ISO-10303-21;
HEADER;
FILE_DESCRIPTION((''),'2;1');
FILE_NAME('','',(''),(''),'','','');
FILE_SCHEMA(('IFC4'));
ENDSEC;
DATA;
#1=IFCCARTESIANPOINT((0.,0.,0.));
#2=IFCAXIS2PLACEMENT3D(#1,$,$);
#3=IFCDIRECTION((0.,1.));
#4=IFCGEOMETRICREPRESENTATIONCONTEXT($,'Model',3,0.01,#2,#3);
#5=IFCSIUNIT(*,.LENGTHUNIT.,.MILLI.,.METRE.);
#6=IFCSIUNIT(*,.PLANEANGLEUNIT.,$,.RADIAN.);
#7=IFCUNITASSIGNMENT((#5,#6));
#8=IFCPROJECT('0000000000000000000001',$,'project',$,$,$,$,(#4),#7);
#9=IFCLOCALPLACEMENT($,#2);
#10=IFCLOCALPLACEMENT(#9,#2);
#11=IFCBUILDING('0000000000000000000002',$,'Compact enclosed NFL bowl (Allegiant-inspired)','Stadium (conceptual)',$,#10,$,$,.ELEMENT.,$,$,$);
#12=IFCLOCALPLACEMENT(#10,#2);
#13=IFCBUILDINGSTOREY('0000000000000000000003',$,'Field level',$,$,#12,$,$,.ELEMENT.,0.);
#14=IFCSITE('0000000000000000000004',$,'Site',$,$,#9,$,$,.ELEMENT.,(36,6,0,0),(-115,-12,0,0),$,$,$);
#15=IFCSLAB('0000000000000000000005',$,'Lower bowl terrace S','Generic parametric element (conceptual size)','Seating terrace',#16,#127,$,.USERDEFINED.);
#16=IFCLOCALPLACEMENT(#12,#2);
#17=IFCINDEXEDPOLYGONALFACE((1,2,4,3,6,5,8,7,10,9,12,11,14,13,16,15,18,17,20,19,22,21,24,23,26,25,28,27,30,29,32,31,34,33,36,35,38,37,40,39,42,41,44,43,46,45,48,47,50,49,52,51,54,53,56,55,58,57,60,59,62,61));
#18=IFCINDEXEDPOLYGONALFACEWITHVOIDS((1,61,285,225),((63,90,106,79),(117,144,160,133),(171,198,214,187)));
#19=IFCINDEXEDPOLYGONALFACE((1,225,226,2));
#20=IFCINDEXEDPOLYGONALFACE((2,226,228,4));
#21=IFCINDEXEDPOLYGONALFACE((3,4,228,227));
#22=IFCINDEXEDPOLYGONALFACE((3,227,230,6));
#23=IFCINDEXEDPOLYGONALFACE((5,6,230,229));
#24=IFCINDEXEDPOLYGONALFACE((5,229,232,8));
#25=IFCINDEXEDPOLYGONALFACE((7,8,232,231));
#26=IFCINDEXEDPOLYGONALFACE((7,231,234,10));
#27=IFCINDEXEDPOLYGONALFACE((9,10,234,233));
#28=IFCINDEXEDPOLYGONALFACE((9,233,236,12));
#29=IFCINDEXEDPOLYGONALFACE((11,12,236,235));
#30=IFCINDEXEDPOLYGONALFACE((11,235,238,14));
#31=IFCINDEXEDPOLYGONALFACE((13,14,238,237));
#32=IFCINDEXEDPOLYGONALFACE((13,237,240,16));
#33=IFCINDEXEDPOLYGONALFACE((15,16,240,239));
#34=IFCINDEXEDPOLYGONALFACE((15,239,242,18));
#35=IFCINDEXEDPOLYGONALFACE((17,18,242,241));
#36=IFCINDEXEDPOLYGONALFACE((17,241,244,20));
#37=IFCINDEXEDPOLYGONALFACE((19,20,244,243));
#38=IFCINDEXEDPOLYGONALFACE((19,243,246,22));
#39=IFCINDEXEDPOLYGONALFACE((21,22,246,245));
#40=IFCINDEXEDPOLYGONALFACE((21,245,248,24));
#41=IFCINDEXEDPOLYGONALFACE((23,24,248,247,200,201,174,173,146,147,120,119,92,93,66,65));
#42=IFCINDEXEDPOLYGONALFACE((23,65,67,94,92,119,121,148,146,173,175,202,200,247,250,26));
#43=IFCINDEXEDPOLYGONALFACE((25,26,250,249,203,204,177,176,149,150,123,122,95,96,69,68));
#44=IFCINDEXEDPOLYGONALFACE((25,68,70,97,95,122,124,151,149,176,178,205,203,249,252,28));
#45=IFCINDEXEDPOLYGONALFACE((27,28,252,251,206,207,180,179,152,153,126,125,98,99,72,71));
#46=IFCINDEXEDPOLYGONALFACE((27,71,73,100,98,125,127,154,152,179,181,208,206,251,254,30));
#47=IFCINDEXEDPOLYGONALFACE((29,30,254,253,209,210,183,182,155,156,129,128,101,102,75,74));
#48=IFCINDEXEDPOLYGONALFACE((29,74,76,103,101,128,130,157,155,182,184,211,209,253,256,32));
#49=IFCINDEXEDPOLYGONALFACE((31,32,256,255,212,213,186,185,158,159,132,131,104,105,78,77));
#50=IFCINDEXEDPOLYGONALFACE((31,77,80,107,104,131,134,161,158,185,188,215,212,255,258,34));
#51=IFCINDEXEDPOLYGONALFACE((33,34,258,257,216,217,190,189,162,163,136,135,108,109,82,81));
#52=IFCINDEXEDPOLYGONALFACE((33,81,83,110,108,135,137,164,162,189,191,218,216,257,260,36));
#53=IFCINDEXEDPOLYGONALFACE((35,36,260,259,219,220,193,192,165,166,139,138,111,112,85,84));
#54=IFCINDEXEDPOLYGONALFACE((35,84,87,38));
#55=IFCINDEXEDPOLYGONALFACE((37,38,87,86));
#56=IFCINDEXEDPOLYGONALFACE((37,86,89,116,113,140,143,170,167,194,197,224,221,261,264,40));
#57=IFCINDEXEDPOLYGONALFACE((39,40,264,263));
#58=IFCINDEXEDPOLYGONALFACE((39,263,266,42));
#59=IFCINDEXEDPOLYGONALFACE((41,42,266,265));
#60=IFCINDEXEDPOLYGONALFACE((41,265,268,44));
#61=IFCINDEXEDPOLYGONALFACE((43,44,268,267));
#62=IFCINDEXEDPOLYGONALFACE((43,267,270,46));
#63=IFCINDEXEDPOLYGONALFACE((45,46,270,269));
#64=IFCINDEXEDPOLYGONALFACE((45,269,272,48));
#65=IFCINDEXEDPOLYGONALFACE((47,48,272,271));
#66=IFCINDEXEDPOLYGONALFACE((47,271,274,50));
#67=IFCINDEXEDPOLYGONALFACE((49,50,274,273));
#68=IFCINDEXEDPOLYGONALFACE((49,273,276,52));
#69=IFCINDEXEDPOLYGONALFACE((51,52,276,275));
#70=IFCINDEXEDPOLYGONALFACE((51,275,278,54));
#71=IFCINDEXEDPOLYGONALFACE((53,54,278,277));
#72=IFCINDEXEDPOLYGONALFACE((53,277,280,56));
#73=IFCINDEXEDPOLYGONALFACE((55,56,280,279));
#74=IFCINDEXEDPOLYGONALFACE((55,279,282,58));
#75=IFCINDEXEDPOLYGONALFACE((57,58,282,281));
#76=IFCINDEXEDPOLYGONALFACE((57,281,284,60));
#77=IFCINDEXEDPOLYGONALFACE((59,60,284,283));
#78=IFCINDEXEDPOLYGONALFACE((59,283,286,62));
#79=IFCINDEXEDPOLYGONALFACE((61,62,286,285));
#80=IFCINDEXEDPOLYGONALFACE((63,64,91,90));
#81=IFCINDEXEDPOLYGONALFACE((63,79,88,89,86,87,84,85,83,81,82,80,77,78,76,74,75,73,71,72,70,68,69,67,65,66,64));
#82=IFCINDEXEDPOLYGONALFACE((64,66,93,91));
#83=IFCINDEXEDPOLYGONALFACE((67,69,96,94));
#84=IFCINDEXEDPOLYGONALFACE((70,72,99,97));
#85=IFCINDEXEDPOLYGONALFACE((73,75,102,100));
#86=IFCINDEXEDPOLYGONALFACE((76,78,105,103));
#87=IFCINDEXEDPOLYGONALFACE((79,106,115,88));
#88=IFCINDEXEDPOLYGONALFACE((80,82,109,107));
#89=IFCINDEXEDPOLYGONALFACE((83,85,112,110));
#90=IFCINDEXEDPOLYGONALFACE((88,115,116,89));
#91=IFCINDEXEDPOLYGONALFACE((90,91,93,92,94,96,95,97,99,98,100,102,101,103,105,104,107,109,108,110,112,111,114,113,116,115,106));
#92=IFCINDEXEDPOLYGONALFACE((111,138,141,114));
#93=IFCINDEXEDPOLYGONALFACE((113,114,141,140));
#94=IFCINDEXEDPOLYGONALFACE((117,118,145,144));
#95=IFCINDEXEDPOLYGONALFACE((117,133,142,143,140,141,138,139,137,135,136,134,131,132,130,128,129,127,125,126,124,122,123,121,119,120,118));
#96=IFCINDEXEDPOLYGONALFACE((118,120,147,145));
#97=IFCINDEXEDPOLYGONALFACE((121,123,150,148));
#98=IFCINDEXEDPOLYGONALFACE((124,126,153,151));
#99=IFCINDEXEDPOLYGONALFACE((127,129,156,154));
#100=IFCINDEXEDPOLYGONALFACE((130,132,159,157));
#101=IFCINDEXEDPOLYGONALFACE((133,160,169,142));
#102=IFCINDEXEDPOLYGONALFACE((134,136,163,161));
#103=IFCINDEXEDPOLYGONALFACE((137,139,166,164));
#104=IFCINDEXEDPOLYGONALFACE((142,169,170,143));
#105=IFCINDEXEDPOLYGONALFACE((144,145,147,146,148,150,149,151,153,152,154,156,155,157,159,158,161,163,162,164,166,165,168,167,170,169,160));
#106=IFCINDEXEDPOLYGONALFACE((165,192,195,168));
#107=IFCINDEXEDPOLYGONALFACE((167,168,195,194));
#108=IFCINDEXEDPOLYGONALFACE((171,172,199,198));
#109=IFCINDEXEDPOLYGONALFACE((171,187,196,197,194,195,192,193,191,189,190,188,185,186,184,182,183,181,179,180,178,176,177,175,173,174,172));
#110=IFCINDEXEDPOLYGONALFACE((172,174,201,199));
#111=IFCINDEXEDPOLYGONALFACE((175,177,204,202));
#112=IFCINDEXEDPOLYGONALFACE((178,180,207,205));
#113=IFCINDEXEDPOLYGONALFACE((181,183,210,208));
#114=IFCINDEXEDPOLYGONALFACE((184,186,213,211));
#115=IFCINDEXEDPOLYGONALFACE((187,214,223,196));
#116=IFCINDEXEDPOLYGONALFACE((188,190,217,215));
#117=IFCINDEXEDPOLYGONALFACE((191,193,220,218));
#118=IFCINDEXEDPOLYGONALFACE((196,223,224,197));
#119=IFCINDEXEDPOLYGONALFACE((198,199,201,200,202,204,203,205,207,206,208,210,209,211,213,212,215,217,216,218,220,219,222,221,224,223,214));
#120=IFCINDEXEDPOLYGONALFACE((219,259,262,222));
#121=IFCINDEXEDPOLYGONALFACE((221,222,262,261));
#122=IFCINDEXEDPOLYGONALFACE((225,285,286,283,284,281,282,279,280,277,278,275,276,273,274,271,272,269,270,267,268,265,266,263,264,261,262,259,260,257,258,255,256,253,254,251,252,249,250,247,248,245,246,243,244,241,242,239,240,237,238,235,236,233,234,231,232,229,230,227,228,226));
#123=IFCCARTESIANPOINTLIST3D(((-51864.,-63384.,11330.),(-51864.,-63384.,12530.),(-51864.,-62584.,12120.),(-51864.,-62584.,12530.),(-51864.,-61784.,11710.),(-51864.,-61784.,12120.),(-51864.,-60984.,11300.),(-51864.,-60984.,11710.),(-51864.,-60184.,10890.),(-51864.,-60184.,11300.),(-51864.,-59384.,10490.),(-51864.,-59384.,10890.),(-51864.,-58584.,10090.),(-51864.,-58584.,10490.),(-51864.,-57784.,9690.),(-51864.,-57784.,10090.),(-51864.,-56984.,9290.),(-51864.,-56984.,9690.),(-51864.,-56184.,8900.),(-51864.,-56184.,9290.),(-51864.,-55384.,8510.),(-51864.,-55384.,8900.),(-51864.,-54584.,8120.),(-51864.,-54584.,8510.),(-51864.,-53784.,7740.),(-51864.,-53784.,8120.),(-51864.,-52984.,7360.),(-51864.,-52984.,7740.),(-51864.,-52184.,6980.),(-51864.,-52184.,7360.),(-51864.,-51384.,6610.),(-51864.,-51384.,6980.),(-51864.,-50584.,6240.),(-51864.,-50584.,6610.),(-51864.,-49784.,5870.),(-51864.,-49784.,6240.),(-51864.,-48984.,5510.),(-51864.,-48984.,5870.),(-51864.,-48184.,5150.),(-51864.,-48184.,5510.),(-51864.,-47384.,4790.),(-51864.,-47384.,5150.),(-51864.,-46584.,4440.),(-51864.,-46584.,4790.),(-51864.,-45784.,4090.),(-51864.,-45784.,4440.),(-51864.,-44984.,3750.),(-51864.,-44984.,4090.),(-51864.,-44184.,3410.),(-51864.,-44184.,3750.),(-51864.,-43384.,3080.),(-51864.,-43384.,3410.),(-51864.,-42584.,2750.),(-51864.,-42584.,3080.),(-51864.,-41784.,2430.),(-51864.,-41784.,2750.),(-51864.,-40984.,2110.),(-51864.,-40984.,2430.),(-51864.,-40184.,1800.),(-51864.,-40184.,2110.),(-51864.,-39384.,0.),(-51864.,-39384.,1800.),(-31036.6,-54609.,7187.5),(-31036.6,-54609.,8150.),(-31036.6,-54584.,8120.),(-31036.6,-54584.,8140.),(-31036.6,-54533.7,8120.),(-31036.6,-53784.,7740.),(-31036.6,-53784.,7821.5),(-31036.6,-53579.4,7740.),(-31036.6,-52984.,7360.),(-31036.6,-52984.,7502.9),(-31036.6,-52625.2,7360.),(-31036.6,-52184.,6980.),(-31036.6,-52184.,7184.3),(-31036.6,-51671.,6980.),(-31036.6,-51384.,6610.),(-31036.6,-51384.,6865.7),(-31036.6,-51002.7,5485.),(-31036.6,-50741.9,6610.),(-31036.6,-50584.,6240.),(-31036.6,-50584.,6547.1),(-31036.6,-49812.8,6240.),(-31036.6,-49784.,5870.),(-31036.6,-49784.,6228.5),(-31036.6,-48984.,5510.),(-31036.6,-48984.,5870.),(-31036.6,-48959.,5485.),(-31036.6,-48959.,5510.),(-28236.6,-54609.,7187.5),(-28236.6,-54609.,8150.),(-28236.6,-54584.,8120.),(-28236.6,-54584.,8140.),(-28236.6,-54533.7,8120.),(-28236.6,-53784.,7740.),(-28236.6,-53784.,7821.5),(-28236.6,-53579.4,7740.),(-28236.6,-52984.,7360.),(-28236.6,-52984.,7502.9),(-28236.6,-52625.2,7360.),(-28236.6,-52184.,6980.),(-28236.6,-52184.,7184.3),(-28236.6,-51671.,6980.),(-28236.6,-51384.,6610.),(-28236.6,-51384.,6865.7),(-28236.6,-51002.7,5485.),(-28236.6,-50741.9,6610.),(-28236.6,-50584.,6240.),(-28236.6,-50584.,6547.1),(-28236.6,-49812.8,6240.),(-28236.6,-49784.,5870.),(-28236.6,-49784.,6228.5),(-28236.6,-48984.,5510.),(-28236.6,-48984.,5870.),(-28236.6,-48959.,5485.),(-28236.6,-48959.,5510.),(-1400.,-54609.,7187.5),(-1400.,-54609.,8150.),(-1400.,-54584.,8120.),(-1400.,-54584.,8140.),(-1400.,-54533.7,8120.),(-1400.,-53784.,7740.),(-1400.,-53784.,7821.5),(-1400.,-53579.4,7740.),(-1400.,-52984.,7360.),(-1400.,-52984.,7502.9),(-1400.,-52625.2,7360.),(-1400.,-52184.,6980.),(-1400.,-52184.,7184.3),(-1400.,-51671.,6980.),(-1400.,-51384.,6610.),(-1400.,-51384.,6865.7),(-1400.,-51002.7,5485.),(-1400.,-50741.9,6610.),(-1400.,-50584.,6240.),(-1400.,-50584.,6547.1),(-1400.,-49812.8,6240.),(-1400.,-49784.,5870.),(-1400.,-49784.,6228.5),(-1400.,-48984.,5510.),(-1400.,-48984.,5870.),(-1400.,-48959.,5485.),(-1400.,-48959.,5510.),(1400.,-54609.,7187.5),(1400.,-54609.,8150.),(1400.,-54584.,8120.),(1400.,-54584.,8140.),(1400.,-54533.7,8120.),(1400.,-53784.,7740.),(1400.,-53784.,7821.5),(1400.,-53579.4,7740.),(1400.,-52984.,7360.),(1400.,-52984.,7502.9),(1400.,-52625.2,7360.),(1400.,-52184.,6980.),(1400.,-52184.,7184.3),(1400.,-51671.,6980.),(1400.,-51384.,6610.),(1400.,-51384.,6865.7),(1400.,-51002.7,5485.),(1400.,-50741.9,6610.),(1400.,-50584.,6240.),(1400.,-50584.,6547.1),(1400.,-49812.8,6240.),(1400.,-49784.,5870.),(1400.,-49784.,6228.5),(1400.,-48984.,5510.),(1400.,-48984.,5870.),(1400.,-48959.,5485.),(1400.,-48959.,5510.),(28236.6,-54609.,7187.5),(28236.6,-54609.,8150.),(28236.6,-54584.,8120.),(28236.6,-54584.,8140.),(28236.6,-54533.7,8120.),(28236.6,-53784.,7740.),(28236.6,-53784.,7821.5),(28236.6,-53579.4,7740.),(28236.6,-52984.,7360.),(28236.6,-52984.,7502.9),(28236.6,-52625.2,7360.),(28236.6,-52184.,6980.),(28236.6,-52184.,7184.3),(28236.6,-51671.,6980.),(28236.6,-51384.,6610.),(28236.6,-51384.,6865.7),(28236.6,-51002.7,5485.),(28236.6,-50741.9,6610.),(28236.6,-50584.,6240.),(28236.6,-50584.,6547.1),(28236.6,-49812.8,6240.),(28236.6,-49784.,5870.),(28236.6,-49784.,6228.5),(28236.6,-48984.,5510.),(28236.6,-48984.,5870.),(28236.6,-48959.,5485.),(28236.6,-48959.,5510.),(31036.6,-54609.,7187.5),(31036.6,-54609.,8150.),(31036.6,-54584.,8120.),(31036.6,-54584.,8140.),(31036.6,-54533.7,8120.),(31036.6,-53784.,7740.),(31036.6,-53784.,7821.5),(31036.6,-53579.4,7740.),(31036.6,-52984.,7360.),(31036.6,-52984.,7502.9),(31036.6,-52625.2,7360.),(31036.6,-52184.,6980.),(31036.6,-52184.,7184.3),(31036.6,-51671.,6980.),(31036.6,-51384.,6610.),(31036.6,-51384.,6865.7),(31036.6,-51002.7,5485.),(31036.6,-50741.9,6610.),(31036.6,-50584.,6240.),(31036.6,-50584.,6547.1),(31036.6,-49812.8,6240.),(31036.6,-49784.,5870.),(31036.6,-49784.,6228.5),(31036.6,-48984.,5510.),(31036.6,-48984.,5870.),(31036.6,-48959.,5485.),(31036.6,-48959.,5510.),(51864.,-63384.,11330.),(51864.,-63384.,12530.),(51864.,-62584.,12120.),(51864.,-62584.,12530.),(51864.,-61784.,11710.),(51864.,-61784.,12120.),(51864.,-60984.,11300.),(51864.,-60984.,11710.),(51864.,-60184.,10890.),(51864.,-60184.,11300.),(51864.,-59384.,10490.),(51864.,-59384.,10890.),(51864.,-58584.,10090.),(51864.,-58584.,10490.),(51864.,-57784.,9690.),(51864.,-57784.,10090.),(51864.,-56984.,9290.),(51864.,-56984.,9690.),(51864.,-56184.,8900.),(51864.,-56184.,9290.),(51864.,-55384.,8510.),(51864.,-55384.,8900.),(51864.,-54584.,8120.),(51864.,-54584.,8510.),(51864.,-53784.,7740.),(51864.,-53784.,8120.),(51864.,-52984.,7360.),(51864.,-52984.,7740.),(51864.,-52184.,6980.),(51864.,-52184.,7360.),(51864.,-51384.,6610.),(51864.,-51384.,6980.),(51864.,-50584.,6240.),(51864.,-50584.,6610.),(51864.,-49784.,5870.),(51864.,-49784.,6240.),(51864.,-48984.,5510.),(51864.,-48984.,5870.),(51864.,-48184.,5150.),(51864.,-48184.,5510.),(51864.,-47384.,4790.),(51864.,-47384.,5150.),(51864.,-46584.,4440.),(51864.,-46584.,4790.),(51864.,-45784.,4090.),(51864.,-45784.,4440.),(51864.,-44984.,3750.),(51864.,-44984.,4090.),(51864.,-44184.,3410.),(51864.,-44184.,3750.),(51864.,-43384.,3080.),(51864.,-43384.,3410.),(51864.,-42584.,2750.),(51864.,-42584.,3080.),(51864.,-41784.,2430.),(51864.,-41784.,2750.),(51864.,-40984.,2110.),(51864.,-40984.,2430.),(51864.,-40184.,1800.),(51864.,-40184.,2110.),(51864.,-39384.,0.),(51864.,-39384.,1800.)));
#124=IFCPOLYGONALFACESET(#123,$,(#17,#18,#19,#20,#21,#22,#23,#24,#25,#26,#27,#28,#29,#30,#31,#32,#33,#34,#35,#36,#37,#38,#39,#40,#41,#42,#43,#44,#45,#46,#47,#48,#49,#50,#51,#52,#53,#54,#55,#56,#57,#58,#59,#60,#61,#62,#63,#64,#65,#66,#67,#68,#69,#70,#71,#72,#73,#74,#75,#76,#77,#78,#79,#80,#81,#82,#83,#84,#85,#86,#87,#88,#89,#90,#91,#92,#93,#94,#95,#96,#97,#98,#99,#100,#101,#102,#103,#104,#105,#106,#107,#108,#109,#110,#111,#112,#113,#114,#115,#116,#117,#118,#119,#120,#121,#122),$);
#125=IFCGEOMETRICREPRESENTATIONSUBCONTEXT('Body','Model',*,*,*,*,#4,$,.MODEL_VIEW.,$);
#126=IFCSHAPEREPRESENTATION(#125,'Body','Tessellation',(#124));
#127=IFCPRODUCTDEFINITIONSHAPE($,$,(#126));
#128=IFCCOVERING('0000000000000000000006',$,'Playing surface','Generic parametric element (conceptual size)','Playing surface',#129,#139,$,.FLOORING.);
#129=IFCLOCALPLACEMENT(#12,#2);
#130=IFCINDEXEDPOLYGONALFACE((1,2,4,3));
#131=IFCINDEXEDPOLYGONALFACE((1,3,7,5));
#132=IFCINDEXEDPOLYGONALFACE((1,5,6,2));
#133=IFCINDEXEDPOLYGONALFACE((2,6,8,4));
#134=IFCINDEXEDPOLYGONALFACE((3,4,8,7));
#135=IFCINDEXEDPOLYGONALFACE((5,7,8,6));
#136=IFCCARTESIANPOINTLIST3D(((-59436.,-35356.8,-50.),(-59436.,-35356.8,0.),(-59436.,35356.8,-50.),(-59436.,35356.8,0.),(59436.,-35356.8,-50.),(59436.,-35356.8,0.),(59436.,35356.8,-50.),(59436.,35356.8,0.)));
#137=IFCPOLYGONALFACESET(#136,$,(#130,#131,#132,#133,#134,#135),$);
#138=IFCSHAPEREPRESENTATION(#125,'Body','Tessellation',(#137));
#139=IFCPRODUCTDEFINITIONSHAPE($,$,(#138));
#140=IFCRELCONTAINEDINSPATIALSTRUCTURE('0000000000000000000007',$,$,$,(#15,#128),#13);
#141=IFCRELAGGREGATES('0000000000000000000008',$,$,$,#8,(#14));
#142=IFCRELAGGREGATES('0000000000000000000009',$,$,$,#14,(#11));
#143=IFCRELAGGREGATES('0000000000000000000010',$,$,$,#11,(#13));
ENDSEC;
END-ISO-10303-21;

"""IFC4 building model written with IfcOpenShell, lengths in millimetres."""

from ifc_helpers import new_model, si_unit, direction, frame, origin, place, context, subcontext, project, spatial, line, indexed_curve, rectangle, outline, extrude, element, save


model = new_model("IFC4")

# Units and contexts
model_context = context("Model", 3, precision=0.01, world=origin(), true_north=direction((0.0, 1.0)))
body_context = subcontext(model_context, "Body", "Model", "MODEL_VIEW")
ifc_project = project(units=[si_unit("LENGTHUNIT", "METRE", prefix="MILLI"), si_unit("PLANEANGLEUNIT", "RADIAN")], contexts=[model_context])

# Site, building, storey
site_placement = place(None, origin())
site = spatial("IfcSite", under=ifc_project, at=site_placement, Name="Site", CompositionType="ELEMENT", RefLatitude=(36, 6, 0, 0), RefLongitude=(-115, -12, 0, 0))
building_placement = place(site_placement, origin())
building = spatial("IfcBuilding", under=site, at=building_placement, Name="Compact enclosed NFL bowl (Allegiant-inspired)", Description="Stadium (conceptual)", CompositionType="ELEMENT")
storey_placement = place(building_placement, origin())
storey = spatial("IfcBuildingStorey", under=building, at=storey_placement, Name="Field level", CompositionType="ELEMENT", Elevation=0.0)

# Shared definitions
placement = place(storey_placement, origin())

# Slab, openings
slab_1 = element("IfcSlab", 1, at=placement, inside=storey, Name="Lower bowl terrace S", Description="Generic parametric element (conceptual size)", ObjectType="Seating terrace", PredefinedType="USERDEFINED", context=body_context, shape_type="SweptSolid", body=[
    extrude(outline(indexed_curve([(24000.0, 11330.0), (24000.0, 12530.0), (23200.0, 12530.0), (23200.0, 12120.0), (22400.0, 12120.0), (22400.0, 11710.0), (21600.0, 11710.0), (21600.0, 11300.0), (20800.0, 11300.0), (20800.0, 10890.0), (20000.0, 10890.0), (20000.0, 10490.0), (19200.0, 10490.0), (19200.0, 10090.0), (18400.0, 10090.0), (18400.0, 9690.0), (17600.0, 9690.0), (17600.0, 9290.0), (16800.0, 9290.0), (16800.0, 8900.0), (16000.0, 8900.0), (16000.0, 8510.0), (15200.0, 8510.0), (15200.0, 8120.0), (14400.0, 8120.0), (14400.0, 7740.0), (13600.0, 7740.0), (13600.0, 7360.0), (12800.0, 7360.0), (12800.0, 6980.0), (12000.0, 6980.0), (12000.0, 6610.0), (11200.0, 6610.0), (11200.0, 6240.0), (10400.0, 6240.0), (10400.0, 5870.0), (9600.0, 5870.0), (9600.0, 5510.0), (8800.0, 5510.0), (8800.0, 5150.0), (8000.0, 5150.0), (8000.0, 4790.0), (7200.0, 4790.0), (7200.0, 4440.0), (6400.0, 4440.0), (6400.0, 4090.0), (5600.0, 4090.0), (5600.0, 3750.0), (4800.0, 3750.0), (4800.0, 3410.0), (4000.0, 3410.0), (4000.0, 3080.0), (3200.0, 3080.0), (3200.0, 2750.0), (2400.0, 2750.0), (2400.0, 2430.0), (1600.0, 2430.0), (1600.0, 2110.0), (800.0, 2110.0), (800.0, 1800.0), (0.0, 1800.0), (0.0, 0.0)], segments=[line(1, 2, 3, 4, 5, 6, 7, 8, 9, 10, 11, 12, 13, 14, 15, 16, 17, 18, 19, 20, 21, 22, 23, 24, 25, 26, 27, 28, 29, 30, 31, 32, 33, 34, 35, 36, 37, 38, 39, 40, 41, 42, 43, 44, 45, 46, 47, 48, 49, 50, 51, 52, 53, 54, 55, 56, 57, 58, 59, 60, 61, 62, 1)], self_intersect=False)), frame((51864.0, -39384.0, 0.0), z_axis=(-1.0, 0.0, 0.0), x_axis=(0.0, -1.0, 0.0)), (0.0, 0.0, 1.0), 103728.0),
])
opening_1_placement = place(placement, origin())
element("IfcOpeningElement", 2, at=opening_1_placement, cuts=slab_1, ObjectType="Vomitory", PredefinedType="OPENING", context=body_context, shape_type="SweptSolid", body=[
    extrude(outline(indexed_curve([(9575.0, 5485.0), (15225.0, 5485.0), (15225.0, 8150.0), (9575.0, 5900.0)], segments=[line(1, 2, 3, 4, 1)], self_intersect=False)), frame((-28236.6, -39384.0, 0.0), z_axis=(-1.0, 0.0, 0.0), x_axis=(0.0, -1.0, 0.0)), (0.0, 0.0, 1.0), 2800.0),
])
opening_2_placement = place(placement, origin())
element("IfcOpeningElement", 3, at=opening_2_placement, cuts=slab_1, ObjectType="Vomitory", PredefinedType="OPENING", context=body_context, shape_type="SweptSolid", body=[
    extrude(outline(indexed_curve([(9575.0, 5485.0), (15225.0, 5485.0), (15225.0, 8150.0), (9575.0, 5900.0)], segments=[line(1, 2, 3, 4, 1)], self_intersect=False)), frame((1400.0, -39384.0, 0.0), z_axis=(-1.0, 0.0, 0.0), x_axis=(0.0, -1.0, 0.0)), (0.0, 0.0, 1.0), 2800.0),
])
opening_3_placement = place(placement, origin())
element("IfcOpeningElement", 4, at=opening_3_placement, cuts=slab_1, ObjectType="Vomitory", PredefinedType="OPENING", context=body_context, shape_type="SweptSolid", body=[
    extrude(outline(indexed_curve([(9575.0, 5485.0), (15225.0, 5485.0), (15225.0, 8150.0), (9575.0, 5900.0)], segments=[line(1, 2, 3, 4, 1)], self_intersect=False)), frame((31036.6, -39384.0, 0.0), z_axis=(-1.0, 0.0, 0.0), x_axis=(0.0, -1.0, 0.0)), (0.0, 0.0, 1.0), 2800.0),
])

# Covering
element("IfcCovering", 5, at=placement, inside=storey, Name="Playing surface", Description="Generic parametric element (conceptual size)", ObjectType="Playing surface", PredefinedType="FLOORING", context=body_context, shape_type="SweptSolid", body=[
    extrude(rectangle(XDim=118872.0, YDim=70713.6), frame((0.0, 0.0, -50.0)), (0.0, 0.0, 1.0), 50.0),
])

save(model, "model.ifc")
